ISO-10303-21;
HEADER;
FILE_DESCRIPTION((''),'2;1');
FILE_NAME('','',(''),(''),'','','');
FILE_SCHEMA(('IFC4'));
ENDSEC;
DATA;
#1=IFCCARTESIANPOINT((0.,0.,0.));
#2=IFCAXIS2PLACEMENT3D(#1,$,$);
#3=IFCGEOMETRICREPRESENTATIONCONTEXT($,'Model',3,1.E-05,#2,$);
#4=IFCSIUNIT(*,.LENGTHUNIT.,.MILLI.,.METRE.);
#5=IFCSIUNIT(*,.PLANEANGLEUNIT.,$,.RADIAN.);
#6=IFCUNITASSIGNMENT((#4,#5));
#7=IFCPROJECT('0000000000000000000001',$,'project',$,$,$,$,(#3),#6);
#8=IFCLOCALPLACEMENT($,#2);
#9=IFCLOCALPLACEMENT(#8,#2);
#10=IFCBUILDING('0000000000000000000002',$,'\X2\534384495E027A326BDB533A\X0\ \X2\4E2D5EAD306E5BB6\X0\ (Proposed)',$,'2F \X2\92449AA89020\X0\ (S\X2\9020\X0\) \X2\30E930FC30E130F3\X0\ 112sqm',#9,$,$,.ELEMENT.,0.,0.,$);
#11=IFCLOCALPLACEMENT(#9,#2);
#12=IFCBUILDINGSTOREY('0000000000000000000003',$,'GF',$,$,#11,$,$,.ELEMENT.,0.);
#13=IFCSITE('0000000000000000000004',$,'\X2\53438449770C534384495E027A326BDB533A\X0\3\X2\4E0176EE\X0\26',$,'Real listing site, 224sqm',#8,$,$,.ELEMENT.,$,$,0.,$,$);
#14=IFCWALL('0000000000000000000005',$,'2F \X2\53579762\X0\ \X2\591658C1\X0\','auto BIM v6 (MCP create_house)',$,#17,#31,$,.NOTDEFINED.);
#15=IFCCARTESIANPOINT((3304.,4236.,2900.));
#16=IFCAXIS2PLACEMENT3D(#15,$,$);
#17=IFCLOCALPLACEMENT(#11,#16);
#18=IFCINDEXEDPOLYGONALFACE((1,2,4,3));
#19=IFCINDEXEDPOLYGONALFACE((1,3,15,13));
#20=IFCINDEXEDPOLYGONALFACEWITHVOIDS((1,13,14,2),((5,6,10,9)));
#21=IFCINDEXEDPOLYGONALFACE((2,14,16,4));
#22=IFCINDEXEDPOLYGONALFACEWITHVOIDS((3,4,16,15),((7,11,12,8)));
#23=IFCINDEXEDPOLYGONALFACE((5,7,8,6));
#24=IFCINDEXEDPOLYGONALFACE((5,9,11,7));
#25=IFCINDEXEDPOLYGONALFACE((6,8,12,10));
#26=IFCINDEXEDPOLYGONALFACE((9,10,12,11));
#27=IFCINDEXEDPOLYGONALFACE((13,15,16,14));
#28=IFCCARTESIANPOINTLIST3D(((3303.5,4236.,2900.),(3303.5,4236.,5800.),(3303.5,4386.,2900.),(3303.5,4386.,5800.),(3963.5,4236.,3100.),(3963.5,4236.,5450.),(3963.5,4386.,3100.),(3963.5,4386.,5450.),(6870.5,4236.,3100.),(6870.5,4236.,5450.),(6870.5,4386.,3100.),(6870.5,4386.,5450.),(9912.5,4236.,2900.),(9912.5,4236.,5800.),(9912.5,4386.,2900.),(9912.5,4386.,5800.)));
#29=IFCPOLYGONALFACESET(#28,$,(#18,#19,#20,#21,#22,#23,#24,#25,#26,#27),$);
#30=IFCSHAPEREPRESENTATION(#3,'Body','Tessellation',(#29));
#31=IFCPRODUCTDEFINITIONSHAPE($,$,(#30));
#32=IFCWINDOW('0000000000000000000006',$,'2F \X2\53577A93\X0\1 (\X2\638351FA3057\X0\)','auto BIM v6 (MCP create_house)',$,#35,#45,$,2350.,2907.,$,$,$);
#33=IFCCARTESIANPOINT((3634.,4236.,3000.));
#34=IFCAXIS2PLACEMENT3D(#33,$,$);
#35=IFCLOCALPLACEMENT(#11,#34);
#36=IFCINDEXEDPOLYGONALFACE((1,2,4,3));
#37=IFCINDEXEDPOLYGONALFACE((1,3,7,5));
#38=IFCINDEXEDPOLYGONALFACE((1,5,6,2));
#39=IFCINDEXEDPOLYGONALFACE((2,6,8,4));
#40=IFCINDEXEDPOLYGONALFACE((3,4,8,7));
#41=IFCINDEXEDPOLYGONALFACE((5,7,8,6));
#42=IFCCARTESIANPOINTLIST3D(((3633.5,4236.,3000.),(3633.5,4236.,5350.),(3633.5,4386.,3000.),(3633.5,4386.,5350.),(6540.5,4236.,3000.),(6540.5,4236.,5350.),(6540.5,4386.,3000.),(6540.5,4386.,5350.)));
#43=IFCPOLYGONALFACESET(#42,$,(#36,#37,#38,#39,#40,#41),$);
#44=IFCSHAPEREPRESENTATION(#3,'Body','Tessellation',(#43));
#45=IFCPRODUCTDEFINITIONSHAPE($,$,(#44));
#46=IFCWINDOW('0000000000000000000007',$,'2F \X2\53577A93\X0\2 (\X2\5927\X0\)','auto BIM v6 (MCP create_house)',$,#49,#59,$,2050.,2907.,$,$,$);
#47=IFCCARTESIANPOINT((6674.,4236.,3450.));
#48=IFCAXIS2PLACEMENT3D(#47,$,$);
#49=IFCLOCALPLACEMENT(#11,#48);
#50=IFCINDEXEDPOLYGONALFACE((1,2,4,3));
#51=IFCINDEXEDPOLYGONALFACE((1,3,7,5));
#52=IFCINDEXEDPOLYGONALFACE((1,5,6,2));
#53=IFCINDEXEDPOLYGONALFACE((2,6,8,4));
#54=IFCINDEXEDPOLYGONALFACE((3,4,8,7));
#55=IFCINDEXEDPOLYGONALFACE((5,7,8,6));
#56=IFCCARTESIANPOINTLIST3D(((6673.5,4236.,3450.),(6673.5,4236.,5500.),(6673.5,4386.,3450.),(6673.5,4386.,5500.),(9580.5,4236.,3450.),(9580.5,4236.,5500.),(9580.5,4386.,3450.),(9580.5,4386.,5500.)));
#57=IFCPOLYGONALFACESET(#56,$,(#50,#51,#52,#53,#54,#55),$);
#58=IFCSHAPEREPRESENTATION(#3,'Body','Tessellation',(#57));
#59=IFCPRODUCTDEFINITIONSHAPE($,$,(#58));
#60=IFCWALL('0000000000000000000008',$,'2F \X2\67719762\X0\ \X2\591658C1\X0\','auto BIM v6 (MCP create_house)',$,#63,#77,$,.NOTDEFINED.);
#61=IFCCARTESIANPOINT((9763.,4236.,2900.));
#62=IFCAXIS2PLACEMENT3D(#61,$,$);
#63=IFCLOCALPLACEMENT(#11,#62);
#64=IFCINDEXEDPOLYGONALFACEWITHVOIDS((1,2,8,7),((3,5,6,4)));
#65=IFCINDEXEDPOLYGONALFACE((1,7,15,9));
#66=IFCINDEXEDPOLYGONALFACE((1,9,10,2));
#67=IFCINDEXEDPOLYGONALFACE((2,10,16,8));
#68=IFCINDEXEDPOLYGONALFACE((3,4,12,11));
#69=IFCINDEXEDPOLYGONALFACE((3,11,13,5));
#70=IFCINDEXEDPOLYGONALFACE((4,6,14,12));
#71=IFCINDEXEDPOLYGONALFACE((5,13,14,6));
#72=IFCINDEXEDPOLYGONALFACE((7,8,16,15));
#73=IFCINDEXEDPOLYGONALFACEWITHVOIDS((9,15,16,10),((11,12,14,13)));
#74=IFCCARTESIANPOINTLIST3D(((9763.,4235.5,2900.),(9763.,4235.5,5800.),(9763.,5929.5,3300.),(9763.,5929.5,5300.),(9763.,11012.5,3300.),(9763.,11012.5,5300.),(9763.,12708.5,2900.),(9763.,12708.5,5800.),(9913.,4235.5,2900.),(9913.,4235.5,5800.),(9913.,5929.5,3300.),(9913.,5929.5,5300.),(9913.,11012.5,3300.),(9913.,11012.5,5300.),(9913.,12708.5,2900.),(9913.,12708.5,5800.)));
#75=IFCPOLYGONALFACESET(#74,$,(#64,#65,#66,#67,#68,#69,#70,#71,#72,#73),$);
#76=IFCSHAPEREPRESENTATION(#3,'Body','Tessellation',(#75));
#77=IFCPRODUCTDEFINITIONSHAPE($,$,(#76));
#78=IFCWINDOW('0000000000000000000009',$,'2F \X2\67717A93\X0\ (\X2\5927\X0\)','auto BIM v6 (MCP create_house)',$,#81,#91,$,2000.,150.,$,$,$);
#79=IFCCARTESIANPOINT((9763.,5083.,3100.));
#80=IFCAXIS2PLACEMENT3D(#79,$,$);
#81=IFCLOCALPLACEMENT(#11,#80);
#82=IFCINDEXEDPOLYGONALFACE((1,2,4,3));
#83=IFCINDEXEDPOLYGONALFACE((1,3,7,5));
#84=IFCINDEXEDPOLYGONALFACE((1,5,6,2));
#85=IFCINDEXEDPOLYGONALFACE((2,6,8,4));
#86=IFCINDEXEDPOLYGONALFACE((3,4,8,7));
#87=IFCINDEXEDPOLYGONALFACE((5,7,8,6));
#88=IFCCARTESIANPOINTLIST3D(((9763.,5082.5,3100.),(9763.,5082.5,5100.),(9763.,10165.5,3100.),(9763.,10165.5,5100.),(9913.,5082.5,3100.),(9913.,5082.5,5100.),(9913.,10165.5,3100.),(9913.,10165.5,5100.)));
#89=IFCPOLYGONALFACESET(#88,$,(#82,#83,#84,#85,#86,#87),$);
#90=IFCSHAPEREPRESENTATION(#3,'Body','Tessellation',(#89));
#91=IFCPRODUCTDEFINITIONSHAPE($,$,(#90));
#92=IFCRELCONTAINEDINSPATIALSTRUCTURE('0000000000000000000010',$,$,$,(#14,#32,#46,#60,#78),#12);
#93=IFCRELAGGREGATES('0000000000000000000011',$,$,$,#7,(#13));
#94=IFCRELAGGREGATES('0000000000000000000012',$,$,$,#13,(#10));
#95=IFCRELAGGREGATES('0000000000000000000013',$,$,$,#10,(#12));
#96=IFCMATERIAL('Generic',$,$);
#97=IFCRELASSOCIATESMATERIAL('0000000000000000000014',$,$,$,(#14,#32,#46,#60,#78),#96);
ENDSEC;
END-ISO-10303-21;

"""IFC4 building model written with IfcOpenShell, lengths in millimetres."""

from ifc_helpers import new_model, si_unit, frame, frame_2d, origin, place, context, project, spatial, rectangle, extrude, material, element, fill, save


model = new_model("IFC4")

# Units and contexts
model_context = context("Model", 3, precision=1e-05, world=origin())
ifc_project = project(units=[si_unit("LENGTHUNIT", "METRE", prefix="MILLI"), si_unit("PLANEANGLEUNIT", "RADIAN")], contexts=[model_context])

# Site, building, storey
site_placement = place(None, origin())
site = spatial("IfcSite", under=ifc_project, at=site_placement, Name="千葉県千葉市稲毛区3丁目26", ObjectType="Real listing site, 224sqm", CompositionType="ELEMENT", RefElevation=0.0)
building_placement = place(site_placement, origin())
building = spatial("IfcBuilding", under=site, at=building_placement, Name="千葉市稲毛区 中庭の家 (Proposed)", ObjectType="2F 鉄骨造 (S造) ラーメン 112sqm", CompositionType="ELEMENT", ElevationOfRefHeight=0.0, ElevationOfTerrain=0.0)
storey_placement = place(building_placement, origin())
storey = spatial("IfcBuildingStorey", under=building, at=storey_placement, Name="GF", CompositionType="ELEMENT", Elevation=0.0)

# Shared definitions
ifc_material = material(Name="Generic")

# Wall, openings, windows
wall_1_placement = place(storey_placement, frame((3304.0, 4236.0, 2900.0)))
wall_1 = element("IfcWall", 1, at=wall_1_placement, inside=storey, material=ifc_material, Name="2F 南面 外壁", Description="auto BIM v6 (MCP create_house)", PredefinedType="NOTDEFINED", context=model_context, shape_type="SweptSolid", body=[
    extrude(rectangle(XDim=6609.0, YDim=150.0, at=frame_2d((3304.0, 75.0))), frame((3304.0, 4236.0, 2900.0)), (0.0, 0.0, 1.0), 2900.0),
])
opening_1_placement = place(storey_placement, frame((3634.0, 4236.0, 3000.0)))
opening_1 = element("IfcOpeningElement", 2, at=opening_1_placement, cuts=wall_1, PredefinedType="NOTDEFINED", context=model_context, shape_type="SweptSolid", body=[
    extrude(rectangle(XDim=2907.0, YDim=150.0, at=frame_2d((1453.0, 75.0))), frame((3634.0, 4236.0, 3000.0)), (0.0, 0.0, 1.0), 2350.0),
])
opening_2_placement = place(storey_placement, frame((6674.0, 4236.0, 3450.0)))
opening_2 = element("IfcOpeningElement", 3, at=opening_2_placement, cuts=wall_1, PredefinedType="NOTDEFINED", context=model_context, shape_type="SweptSolid", body=[
    extrude(rectangle(XDim=2907.0, YDim=150.0, at=frame_2d((1453.0, 75.0))), frame((6674.0, 4236.0, 3450.0)), (0.0, 0.0, 1.0), 2050.0),
])
window_1_placement = place(storey_placement, frame((3634.0, 4236.0, 3000.0)))
window_1 = element("IfcWindow", 4, at=window_1_placement, inside=storey, material=ifc_material, Name="2F 南窓1 (掃出し)", Description="auto BIM v6 (MCP create_house)", OverallHeight=2350.0, OverallWidth=2907.0, context=model_context, shape_type="SweptSolid", body=[
    extrude(rectangle(XDim=2907.0, YDim=150.0, at=frame_2d((1453.0, 75.0))), frame((3634.0, 4236.0, 3000.0)), (0.0, 0.0, 1.0), 2350.0),
])
fill(opening_1, window_1)
window_2_placement = place(storey_placement, frame((6674.0, 4236.0, 3450.0)))
window_2 = element("IfcWindow", 5, at=window_2_placement, inside=storey, material=ifc_material, Name="2F 南窓2 (大)", Description="auto BIM v6 (MCP create_house)", OverallHeight=2050.0, OverallWidth=2907.0, context=model_context, shape_type="SweptSolid", body=[
    extrude(rectangle(XDim=2907.0, YDim=150.0, at=frame_2d((1453.0, 75.0))), frame((6674.0, 4236.0, 3450.0)), (0.0, 0.0, 1.0), 2050.0),
])
fill(opening_2, window_2)

# Wall, opening, window
wall_2_placement = place(storey_placement, frame((9763.0, 4236.0, 2900.0)))
wall_2 = element("IfcWall", 6, at=wall_2_placement, inside=storey, material=ifc_material, Name="2F 東面 外壁", Description="auto BIM v6 (MCP create_house)", PredefinedType="NOTDEFINED", context=model_context, shape_type="SweptSolid", body=[
    extrude(rectangle(XDim=150.0, YDim=8473.0, at=frame_2d((75.0, 4236.0))), frame((9763.0, 4236.0, 2900.0)), (0.0, 0.0, 1.0), 2900.0),
])
opening_3_placement = place(storey_placement, frame((9763.0, 5083.0, 3100.0)))
opening_3 = element("IfcOpeningElement", 7, at=opening_3_placement, cuts=wall_2, PredefinedType="NOTDEFINED", context=model_context, shape_type="SweptSolid", body=[
    extrude(rectangle(XDim=150.0, YDim=5083.0, at=frame_2d((75.0, 2541.0))), frame((9763.0, 5083.0, 3100.0)), (0.0, 0.0, 1.0), 2000.0),
])
window_3_placement = place(storey_placement, frame((9763.0, 5083.0, 3100.0)))
window_3 = element("IfcWindow", 8, at=window_3_placement, inside=storey, material=ifc_material, Name="2F 東窓 (大)", Description="auto BIM v6 (MCP create_house)", OverallHeight=2000.0, OverallWidth=150.0, context=model_context, shape_type="SweptSolid", body=[
    extrude(rectangle(XDim=150.0, YDim=5083.0, at=frame_2d((75.0, 2541.0))), frame((9763.0, 5083.0, 3100.0)), (0.0, 0.0, 1.0), 2000.0),
])
fill(opening_3, window_3)

save(model, "model.ifc")
